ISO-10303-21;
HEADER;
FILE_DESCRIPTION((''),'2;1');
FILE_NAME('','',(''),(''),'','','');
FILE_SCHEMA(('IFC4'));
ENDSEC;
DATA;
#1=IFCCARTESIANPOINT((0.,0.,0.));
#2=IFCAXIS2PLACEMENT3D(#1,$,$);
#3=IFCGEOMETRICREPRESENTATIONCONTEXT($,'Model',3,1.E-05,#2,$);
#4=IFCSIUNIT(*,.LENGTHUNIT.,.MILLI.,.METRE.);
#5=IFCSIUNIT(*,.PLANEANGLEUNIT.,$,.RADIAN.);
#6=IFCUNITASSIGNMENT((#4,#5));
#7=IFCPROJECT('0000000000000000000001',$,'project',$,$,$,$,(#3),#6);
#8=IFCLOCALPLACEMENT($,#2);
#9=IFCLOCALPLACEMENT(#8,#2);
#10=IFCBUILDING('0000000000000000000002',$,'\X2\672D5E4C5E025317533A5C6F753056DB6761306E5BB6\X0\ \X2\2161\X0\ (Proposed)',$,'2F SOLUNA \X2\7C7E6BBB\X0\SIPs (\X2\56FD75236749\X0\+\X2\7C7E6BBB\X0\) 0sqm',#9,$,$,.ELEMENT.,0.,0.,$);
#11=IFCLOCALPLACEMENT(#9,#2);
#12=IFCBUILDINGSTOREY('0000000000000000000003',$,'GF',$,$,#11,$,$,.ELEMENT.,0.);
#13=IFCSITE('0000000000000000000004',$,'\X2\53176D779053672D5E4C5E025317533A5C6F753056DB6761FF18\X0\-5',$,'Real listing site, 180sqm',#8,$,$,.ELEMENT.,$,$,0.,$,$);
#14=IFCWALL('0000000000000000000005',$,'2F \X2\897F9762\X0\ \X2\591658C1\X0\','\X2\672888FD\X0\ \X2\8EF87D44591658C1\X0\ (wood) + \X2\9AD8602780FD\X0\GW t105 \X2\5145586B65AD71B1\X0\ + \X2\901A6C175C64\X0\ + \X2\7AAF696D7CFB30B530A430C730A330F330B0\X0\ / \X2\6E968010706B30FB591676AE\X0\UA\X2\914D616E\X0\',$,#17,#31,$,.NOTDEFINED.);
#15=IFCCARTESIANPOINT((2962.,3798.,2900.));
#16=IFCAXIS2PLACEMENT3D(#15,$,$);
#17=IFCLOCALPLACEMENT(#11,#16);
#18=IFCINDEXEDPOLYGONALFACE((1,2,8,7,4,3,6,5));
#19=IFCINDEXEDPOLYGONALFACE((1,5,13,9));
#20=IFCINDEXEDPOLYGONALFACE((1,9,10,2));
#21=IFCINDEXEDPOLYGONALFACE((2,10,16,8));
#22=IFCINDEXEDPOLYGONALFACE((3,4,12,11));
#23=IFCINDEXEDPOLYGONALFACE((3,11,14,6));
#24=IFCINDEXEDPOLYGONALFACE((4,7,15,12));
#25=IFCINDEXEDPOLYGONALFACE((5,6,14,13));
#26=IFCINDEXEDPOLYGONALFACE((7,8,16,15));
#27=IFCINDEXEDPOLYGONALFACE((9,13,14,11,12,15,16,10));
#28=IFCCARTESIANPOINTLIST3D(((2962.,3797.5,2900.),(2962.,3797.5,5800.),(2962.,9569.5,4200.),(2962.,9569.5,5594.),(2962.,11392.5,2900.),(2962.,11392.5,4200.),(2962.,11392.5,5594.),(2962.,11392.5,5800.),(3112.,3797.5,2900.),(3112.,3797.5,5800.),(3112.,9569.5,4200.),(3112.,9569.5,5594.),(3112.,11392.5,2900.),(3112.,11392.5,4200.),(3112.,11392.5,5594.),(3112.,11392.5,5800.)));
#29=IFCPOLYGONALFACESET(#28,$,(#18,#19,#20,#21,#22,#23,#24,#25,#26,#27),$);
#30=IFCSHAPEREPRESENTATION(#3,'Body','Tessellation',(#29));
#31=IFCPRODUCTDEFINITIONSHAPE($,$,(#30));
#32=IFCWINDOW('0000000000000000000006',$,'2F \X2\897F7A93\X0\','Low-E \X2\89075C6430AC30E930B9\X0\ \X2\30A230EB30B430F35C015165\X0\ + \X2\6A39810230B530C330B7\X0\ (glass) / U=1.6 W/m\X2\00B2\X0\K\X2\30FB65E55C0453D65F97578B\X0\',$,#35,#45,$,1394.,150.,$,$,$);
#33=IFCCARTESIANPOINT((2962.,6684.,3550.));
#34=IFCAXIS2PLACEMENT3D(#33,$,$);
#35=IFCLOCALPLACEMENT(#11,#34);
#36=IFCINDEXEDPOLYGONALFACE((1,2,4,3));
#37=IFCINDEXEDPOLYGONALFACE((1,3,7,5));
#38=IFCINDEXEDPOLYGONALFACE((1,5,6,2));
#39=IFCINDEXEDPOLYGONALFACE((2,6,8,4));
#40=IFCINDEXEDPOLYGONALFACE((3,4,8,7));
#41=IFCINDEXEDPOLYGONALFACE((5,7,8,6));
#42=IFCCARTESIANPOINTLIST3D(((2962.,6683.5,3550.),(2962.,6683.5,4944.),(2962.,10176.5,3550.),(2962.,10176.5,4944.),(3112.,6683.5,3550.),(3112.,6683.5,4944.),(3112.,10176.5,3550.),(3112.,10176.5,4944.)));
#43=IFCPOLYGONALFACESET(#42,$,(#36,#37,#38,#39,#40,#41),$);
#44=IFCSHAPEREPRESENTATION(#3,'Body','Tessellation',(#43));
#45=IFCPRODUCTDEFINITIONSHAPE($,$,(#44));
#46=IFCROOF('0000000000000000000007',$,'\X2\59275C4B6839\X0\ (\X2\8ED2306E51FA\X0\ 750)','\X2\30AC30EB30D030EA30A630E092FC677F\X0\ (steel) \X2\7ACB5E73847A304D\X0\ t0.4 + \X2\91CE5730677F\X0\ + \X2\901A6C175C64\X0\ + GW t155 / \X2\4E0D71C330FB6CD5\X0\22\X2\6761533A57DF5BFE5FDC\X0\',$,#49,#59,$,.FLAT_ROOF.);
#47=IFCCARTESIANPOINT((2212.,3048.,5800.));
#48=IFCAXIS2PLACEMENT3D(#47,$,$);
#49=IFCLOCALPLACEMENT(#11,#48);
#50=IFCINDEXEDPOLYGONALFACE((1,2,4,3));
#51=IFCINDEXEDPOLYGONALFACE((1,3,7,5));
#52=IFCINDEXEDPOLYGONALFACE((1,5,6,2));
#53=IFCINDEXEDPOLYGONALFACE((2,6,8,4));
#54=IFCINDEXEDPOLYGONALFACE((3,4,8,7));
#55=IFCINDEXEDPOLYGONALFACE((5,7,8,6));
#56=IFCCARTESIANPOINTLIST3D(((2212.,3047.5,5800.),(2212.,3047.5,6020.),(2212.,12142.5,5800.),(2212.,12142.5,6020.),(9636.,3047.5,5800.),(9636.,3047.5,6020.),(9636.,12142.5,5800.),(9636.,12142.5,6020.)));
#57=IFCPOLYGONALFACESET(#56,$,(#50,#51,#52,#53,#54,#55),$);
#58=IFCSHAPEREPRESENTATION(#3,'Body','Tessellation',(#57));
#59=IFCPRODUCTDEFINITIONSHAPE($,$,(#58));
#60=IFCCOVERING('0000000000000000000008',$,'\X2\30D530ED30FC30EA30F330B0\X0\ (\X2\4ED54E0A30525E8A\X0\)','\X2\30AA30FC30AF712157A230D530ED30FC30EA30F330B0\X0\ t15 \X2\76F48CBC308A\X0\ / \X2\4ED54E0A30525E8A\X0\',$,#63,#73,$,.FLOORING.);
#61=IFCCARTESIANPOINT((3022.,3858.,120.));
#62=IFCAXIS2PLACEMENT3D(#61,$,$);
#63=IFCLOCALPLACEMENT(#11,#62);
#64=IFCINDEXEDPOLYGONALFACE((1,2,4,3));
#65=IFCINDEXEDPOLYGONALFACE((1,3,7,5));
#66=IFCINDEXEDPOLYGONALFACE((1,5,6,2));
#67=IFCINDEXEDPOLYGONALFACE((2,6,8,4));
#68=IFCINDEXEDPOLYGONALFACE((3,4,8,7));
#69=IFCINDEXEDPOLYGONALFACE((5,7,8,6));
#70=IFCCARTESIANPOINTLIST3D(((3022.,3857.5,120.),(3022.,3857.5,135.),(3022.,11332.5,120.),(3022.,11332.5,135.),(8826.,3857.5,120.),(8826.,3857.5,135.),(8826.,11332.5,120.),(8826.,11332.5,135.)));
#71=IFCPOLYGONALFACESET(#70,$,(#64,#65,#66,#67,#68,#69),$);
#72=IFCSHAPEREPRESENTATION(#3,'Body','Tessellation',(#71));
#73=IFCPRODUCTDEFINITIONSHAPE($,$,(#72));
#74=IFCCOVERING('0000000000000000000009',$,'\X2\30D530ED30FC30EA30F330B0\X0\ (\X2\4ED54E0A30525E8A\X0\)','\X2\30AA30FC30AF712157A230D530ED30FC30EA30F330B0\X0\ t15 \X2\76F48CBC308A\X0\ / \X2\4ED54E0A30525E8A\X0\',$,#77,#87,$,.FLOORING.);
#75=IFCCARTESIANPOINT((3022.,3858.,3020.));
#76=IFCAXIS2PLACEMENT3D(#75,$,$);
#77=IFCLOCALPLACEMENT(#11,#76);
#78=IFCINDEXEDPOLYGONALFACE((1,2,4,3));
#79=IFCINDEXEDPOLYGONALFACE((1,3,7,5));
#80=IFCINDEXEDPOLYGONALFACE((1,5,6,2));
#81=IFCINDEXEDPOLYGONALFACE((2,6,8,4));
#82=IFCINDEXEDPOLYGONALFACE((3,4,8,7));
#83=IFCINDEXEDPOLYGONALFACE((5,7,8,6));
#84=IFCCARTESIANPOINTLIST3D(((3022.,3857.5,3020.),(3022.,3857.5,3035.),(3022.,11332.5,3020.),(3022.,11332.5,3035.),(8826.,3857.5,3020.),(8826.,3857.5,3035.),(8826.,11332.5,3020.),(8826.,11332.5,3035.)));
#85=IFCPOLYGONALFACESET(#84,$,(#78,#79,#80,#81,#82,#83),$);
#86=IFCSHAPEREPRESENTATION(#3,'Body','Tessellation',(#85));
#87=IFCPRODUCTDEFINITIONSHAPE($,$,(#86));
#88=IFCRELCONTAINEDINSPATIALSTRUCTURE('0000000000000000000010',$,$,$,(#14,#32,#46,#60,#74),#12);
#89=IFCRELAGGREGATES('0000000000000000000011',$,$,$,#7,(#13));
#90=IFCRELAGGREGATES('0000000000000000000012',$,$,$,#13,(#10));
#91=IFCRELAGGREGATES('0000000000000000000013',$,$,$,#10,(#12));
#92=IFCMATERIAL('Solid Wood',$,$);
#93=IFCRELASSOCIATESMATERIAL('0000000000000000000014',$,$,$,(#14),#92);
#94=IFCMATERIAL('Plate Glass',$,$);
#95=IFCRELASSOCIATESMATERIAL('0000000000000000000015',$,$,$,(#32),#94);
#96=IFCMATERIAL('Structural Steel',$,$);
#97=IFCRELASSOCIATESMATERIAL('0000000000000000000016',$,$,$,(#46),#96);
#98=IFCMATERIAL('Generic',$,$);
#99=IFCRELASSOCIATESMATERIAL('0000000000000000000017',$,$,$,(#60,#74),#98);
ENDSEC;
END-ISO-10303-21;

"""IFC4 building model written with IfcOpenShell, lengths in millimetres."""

from ifc_helpers import new_model, si_unit, frame, frame_2d, origin, place, context, project, spatial, rectangle, extrude, material, element, fill, save


model = new_model("IFC4")

# Units and contexts
model_context = context("Model", 3, precision=1e-05, world=origin())
ifc_project = project(units=[si_unit("LENGTHUNIT", "METRE", prefix="MILLI"), si_unit("PLANEANGLEUNIT", "RADIAN")], contexts=[model_context])

# Site, building, storey
site_placement = place(None, origin())
site = spatial("IfcSite", under=ifc_project, at=site_placement, Name="北海道札幌市北区屯田四条８-5", ObjectType="Real listing site, 180sqm", CompositionType="ELEMENT", RefElevation=0.0)
building_placement = place(site_placement, origin())
building = spatial("IfcBuilding", under=site, at=building_placement, Name="札幌市北区屯田四条の家 Ⅱ (Proposed)", ObjectType="2F SOLUNA 籾殻SIPs (国産杉+籾殻) 0sqm", CompositionType="ELEMENT", ElevationOfRefHeight=0.0, ElevationOfTerrain=0.0)
storey_placement = place(building_placement, origin())
storey = spatial("IfcBuildingStorey", under=building, at=storey_placement, Name="GF", CompositionType="ELEMENT", Elevation=0.0)

# Shared definitions
ifc_material_1 = material(Name="Solid Wood")

# Shared definitions
ifc_material_2 = material(Name="Plate Glass")

# Wall, opening, window
wall_1_placement = place(storey_placement, frame((2962.0, 3798.0, 2900.0)))
wall_1 = element("IfcWall", 1, at=wall_1_placement, inside=storey, material=ifc_material_1, Name="2F 西面 外壁", Description="木製 軸組外壁 (wood) + 高性能GW t105 充填断熱 + 通気層 + 窯業系サイディング / 準耐火・外皮UA配慮", PredefinedType="NOTDEFINED", context=model_context, shape_type="SweptSolid", body=[
    extrude(rectangle(XDim=150.0, YDim=7595.0, at=frame_2d((75.0, 3797.0))), frame((2962.0, 3798.0, 2900.0)), (0.0, 0.0, 1.0), 2900.0),
])
opening_1_placement = place(storey_placement, frame((2962.0, 6684.0, 3550.0)))
opening_1 = element("IfcOpeningElement", 2, at=opening_1_placement, cuts=wall_1, PredefinedType="NOTDEFINED", context=model_context, shape_type="SweptSolid", body=[
    extrude(rectangle(XDim=150.0, YDim=3493.0, at=frame_2d((75.0, 1746.0))), frame((2962.0, 6684.0, 3550.0)), (0.0, 0.0, 1.0), 1394.0),
])
window_1_placement = place(storey_placement, frame((2962.0, 6684.0, 3550.0)))
window_1 = element("IfcWindow", 3, at=window_1_placement, inside=storey, material=ifc_material_2, Name="2F 西窓", Description="Low-E 複層ガラス アルゴン封入 + 樹脂サッシ (glass) / U=1.6 W/m²K・日射取得型", OverallHeight=1394.0, OverallWidth=150.0, context=model_context, shape_type="SweptSolid", body=[
    extrude(rectangle(XDim=150.0, YDim=3493.0, at=frame_2d((75.0, 1746.0))), frame((2962.0, 6684.0, 3550.0)), (0.0, 0.0, 1.0), 1394.0),
])
fill(opening_1, window_1)

# Roof
ifc_material_3 = material(Name="Structural Steel")
roof_placement = place(storey_placement, frame((2212.0, 3048.0, 5800.0)))
element("IfcRoof", 4, at=roof_placement, inside=storey, material=ifc_material_3, Name="大屋根 (軒の出 750)", Description="ガルバリウム鋼板 (steel) 立平葺き t0.4 + 野地板 + 通気層 + GW t155 / 不燃・法22条区域対応", PredefinedType="FLAT_ROOF", context=model_context, shape_type="SweptSolid", body=[
    extrude(rectangle(XDim=7424.0, YDim=9095.0, at=frame_2d((3712.0, 4547.0))), frame((2212.0, 3048.0, 5800.0)), (0.0, 0.0, 1.0), 220.0),
])

# Coverings
ifc_material_4 = material(Name="Generic")
covering_1_placement = place(storey_placement, frame((3022.0, 3858.0, 120.0)))
element("IfcCovering", 5, at=covering_1_placement, inside=storey, material=ifc_material_4, Name="フローリング (仕上げ床)", Description="オーク無垢フローリング t15 直貼り / 仕上げ床", PredefinedType="FLOORING", context=model_context, shape_type="SweptSolid", body=[
    extrude(rectangle(XDim=5804.0, YDim=7475.0, at=frame_2d((2902.0, 3737.0))), frame((3022.0, 3858.0, 120.0)), (0.0, 0.0, 1.0), 15.0),
])
covering_2_placement = place(storey_placement, frame((3022.0, 3858.0, 3020.0)))
element("IfcCovering", 6, at=covering_2_placement, inside=storey, material=ifc_material_4, Name="フローリング (仕上げ床)", Description="オーク無垢フローリング t15 直貼り / 仕上げ床", PredefinedType="FLOORING", context=model_context, shape_type="SweptSolid", body=[
    extrude(rectangle(XDim=5804.0, YDim=7475.0, at=frame_2d((2902.0, 3737.0))), frame((3022.0, 3858.0, 3020.0)), (0.0, 0.0, 1.0), 15.0),
])

save(model, "model.ifc")
